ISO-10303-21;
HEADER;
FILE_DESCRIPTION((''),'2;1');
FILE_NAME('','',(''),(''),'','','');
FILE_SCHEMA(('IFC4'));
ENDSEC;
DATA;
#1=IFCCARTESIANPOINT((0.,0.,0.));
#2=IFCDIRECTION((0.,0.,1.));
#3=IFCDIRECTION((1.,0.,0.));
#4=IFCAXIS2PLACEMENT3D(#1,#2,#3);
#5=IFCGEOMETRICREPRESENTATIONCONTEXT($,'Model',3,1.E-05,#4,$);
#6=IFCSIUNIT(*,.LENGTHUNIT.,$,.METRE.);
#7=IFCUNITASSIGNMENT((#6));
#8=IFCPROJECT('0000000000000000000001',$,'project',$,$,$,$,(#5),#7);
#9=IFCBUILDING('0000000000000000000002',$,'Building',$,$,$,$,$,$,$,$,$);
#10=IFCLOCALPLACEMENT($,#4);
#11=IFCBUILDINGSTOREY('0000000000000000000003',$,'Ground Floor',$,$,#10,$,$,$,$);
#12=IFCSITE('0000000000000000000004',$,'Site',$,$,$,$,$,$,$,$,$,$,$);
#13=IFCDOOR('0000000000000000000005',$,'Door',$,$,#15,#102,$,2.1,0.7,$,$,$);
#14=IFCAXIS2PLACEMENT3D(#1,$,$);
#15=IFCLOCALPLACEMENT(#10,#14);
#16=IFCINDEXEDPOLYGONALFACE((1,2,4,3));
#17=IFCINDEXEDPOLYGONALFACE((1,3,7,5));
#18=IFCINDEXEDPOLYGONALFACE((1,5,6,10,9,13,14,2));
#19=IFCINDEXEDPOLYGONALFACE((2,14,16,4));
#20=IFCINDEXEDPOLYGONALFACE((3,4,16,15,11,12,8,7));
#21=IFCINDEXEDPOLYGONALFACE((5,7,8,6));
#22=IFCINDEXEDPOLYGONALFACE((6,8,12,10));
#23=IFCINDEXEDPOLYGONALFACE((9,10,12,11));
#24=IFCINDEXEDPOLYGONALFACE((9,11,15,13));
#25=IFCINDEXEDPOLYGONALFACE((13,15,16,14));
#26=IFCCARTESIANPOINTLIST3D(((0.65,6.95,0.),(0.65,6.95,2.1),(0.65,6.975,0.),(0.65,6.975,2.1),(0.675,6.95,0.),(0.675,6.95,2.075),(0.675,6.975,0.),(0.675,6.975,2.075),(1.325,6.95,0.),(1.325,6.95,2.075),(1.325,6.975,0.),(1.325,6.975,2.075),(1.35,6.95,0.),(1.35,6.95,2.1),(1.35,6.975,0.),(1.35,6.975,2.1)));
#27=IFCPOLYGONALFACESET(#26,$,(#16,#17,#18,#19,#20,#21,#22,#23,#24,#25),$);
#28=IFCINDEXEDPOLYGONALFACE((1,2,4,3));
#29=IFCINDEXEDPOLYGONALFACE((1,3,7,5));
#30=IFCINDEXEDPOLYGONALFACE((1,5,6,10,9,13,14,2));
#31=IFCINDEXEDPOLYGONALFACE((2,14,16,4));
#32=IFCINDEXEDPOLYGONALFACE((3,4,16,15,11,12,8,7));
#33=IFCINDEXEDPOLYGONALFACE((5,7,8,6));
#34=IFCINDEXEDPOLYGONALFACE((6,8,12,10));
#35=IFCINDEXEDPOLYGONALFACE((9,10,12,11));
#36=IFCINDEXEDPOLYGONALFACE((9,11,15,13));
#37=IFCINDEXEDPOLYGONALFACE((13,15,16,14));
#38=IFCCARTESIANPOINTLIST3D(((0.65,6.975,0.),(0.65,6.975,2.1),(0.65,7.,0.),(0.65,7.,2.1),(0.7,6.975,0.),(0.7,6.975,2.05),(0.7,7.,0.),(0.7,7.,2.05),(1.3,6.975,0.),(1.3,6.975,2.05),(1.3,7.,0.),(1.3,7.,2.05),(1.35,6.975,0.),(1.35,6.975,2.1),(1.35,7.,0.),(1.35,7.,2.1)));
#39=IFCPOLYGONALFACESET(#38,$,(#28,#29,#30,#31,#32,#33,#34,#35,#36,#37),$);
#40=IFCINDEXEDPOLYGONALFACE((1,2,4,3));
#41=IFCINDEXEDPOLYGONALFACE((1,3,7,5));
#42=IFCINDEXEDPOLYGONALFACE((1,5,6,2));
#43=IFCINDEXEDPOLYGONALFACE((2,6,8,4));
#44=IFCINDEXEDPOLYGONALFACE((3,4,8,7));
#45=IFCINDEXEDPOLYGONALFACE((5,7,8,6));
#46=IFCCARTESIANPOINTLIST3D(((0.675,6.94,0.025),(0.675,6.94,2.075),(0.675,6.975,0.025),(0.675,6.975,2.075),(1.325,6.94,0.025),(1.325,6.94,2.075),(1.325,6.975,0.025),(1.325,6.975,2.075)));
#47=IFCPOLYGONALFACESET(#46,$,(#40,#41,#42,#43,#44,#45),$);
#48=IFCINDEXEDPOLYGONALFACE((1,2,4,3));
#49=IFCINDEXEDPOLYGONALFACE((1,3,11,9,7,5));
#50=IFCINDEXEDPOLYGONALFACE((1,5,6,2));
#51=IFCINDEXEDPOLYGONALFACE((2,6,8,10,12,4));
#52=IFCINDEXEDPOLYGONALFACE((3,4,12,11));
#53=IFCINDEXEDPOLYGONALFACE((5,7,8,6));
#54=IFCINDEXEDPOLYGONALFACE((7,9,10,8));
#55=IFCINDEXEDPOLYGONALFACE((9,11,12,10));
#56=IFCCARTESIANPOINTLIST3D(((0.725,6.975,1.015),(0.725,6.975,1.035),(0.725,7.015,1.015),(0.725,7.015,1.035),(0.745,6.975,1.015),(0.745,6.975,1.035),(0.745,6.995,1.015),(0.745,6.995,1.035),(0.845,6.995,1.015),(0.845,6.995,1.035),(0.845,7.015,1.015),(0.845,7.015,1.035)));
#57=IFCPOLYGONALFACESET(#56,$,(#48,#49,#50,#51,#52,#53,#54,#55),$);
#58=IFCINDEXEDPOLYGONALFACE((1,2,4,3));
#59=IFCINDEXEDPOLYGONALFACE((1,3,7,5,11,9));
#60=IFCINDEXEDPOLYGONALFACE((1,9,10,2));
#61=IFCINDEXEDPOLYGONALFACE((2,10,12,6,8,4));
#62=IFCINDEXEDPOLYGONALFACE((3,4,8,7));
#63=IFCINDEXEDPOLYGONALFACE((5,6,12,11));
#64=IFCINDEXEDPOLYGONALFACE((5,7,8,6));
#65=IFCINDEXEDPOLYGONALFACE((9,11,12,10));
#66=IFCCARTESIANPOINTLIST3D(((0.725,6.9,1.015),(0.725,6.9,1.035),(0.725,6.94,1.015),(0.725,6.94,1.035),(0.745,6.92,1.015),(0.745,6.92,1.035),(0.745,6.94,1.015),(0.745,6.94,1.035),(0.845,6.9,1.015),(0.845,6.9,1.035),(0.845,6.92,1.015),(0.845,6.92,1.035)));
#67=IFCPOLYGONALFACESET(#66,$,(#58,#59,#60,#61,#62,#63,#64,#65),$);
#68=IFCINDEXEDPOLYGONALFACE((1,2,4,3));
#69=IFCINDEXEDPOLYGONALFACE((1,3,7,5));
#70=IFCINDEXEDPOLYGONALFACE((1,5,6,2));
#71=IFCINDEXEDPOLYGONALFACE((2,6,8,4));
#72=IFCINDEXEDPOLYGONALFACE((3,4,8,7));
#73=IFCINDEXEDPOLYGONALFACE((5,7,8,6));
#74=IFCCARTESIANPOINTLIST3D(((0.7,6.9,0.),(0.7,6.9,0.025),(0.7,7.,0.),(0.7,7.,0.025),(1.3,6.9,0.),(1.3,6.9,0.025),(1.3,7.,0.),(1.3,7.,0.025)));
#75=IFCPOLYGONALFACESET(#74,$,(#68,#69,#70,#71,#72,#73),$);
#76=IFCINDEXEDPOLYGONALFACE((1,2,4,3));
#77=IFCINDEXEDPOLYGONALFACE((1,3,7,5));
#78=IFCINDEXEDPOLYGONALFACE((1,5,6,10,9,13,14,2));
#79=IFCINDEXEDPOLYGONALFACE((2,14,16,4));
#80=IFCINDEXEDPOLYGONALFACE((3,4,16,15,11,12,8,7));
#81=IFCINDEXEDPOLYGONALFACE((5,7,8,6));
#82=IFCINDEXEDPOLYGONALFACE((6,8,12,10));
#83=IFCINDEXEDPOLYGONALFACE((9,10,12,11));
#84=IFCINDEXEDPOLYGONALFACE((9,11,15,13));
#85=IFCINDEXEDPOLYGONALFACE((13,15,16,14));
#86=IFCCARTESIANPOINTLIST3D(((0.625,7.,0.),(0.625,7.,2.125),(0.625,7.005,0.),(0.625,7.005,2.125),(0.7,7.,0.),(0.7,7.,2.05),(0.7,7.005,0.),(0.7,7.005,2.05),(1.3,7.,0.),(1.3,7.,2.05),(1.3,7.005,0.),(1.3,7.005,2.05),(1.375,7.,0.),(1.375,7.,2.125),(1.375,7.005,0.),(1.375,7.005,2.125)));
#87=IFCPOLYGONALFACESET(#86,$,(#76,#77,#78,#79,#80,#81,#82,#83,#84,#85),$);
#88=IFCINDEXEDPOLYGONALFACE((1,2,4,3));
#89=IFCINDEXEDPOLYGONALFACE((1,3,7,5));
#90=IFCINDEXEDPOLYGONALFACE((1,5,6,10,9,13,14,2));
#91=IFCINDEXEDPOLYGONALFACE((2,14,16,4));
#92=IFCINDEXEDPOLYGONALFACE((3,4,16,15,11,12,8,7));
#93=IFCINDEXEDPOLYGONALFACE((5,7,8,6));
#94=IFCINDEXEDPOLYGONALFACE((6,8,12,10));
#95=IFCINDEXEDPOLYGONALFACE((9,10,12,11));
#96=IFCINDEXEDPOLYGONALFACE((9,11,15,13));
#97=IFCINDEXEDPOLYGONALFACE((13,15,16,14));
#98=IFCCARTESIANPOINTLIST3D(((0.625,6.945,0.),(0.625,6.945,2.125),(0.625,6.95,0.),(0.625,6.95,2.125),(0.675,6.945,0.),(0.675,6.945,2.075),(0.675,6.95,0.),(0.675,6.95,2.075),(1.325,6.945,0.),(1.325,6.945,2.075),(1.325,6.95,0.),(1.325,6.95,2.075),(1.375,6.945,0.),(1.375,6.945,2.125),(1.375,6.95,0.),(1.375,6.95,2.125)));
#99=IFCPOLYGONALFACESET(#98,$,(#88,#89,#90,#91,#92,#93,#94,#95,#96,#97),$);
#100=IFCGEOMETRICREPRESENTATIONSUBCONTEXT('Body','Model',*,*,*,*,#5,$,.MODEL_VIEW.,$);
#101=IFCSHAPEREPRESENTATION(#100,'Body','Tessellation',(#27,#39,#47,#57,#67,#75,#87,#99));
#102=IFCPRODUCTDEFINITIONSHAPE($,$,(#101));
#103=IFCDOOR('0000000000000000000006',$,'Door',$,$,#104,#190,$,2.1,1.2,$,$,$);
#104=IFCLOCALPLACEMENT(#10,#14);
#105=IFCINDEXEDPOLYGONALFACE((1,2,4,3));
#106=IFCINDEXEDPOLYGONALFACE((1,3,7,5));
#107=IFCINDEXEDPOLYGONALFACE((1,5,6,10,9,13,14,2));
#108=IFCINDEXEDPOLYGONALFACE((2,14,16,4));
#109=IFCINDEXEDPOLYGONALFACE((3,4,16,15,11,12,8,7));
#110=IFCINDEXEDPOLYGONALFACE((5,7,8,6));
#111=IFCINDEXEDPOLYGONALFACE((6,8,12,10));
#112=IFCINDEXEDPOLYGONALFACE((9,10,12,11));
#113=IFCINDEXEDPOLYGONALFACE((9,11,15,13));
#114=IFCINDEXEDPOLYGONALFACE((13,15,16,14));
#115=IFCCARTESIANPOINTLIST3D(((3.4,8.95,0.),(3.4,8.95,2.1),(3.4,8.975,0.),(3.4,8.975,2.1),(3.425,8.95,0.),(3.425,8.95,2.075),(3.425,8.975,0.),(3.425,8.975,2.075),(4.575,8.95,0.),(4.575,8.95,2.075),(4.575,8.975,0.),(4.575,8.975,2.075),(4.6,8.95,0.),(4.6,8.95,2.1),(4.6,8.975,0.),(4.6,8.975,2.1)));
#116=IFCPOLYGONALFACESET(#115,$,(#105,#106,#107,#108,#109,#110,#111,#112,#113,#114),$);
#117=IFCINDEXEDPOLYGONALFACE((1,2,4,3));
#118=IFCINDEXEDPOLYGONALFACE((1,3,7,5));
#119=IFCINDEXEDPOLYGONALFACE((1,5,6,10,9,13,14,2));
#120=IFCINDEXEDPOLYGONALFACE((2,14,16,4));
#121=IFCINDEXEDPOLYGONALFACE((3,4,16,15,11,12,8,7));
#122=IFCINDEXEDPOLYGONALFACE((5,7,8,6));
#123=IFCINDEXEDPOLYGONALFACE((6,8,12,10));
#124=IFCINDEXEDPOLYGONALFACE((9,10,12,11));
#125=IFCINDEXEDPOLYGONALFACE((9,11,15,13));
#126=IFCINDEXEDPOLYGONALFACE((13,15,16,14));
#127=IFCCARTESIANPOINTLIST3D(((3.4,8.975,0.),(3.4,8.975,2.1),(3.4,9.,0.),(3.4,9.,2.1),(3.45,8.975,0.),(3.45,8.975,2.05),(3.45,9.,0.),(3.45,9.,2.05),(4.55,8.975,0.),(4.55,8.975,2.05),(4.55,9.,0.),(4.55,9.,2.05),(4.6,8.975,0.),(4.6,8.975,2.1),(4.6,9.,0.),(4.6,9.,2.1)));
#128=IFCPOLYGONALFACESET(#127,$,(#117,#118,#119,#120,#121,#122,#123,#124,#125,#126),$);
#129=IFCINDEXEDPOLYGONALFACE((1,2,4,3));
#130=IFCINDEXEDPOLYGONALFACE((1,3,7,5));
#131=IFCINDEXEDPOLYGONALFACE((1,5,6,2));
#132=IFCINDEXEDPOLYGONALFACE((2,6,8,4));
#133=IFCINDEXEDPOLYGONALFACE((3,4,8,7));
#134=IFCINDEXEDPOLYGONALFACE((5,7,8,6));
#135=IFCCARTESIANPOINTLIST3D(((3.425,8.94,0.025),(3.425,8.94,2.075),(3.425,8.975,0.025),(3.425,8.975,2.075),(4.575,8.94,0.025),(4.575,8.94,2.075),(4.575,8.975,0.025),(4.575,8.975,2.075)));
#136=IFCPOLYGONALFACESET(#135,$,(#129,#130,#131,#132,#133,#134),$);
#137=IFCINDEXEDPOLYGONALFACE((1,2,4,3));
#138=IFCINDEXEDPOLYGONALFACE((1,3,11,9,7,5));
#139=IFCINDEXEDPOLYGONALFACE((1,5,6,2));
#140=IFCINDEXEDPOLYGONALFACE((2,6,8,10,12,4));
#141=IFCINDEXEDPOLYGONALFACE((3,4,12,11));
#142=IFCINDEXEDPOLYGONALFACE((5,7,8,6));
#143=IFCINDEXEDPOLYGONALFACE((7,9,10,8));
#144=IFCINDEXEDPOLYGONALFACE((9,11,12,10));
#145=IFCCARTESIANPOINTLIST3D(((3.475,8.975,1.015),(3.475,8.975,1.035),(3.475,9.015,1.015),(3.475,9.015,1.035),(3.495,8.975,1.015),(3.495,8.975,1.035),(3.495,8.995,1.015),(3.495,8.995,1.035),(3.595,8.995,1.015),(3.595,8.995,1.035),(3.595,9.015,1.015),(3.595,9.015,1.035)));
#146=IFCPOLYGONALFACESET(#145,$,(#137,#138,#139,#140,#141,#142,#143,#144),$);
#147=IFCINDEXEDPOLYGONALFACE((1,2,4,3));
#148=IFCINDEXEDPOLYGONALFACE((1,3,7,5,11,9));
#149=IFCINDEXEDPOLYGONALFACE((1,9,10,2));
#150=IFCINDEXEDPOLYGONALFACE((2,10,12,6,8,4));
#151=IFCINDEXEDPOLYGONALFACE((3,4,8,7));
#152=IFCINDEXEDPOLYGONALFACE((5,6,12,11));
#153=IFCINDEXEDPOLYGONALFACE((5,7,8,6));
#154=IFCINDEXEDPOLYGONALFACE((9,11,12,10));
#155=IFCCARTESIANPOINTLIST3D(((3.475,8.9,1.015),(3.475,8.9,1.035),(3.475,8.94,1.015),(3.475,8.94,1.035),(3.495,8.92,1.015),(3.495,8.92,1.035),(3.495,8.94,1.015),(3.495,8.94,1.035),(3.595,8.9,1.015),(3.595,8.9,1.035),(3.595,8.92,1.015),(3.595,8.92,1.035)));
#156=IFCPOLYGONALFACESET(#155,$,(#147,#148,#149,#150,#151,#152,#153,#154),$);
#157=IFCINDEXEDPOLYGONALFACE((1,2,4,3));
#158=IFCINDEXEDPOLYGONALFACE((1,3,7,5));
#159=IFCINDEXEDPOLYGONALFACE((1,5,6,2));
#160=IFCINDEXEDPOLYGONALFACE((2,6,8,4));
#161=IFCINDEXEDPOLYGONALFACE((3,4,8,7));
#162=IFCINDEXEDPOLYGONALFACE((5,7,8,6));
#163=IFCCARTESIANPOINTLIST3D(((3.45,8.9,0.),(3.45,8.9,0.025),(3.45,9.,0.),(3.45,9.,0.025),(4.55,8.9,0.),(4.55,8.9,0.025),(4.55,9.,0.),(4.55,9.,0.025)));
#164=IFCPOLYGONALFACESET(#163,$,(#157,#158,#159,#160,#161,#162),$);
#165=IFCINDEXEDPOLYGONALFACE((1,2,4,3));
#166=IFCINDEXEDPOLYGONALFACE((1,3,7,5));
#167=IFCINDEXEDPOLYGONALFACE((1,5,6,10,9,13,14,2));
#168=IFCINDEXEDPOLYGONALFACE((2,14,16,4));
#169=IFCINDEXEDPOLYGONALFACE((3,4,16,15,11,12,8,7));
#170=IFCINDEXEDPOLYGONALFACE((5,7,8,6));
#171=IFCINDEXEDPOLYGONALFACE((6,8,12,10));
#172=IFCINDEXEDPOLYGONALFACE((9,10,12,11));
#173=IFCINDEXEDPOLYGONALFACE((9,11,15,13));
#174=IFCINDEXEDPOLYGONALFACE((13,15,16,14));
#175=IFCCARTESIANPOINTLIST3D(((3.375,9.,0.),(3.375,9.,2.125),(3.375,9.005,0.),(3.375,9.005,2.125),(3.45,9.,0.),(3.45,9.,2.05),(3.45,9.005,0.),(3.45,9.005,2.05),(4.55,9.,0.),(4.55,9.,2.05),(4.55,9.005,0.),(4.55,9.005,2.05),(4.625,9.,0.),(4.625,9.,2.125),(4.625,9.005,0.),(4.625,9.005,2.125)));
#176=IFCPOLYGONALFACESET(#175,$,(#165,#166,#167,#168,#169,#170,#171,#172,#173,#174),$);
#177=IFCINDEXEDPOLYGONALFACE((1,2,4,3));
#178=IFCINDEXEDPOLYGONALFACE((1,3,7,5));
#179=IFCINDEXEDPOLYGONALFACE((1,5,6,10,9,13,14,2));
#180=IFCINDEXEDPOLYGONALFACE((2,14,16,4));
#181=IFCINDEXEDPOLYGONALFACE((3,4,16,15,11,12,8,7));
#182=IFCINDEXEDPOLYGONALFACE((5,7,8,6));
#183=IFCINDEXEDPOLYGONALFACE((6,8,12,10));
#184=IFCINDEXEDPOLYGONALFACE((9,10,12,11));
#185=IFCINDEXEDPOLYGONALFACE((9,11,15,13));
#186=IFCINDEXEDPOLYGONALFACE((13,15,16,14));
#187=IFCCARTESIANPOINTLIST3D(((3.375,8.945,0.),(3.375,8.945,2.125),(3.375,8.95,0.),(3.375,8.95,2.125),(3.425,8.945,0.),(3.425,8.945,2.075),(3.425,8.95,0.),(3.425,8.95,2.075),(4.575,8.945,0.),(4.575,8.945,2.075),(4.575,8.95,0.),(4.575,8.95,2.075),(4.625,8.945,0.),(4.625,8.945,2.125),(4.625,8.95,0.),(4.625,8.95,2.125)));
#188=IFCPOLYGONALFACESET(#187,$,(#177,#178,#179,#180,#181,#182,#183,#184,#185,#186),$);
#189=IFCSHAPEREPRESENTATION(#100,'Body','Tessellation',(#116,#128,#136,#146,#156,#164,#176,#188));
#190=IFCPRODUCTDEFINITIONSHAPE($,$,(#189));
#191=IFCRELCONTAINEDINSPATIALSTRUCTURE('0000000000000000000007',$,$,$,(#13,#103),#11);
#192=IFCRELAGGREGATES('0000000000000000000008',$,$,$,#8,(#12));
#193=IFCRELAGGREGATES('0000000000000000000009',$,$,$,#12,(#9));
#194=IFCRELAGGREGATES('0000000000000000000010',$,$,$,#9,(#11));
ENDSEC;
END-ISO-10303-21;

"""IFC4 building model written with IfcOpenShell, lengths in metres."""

from ifc_helpers import new_model, si_unit, frame, origin_with_axes, place, context, subcontext, project, spatial, line, indexed_curve, outline, extrude, element, save


model = new_model("IFC4")

# Units and contexts
model_context = context("Model", 3, precision=1e-05, world=origin_with_axes())
body_context = subcontext(model_context, "Body", "Model", "MODEL_VIEW")
ifc_project = project(units=[si_unit("LENGTHUNIT", "METRE")], contexts=[model_context])

# Site, building, storey
site = spatial("IfcSite", under=ifc_project, Name="Site")
building = spatial("IfcBuilding", under=site, Name="Building")
storey_placement = place(None, origin_with_axes())
storey = spatial("IfcBuildingStorey", under=building, at=storey_placement, Name="Ground Floor")

# Doors
door_1_placement = place(storey_placement, frame((1.35, 7.0, 0.0), z_axis=(0.0, 0.0, 1.0), x_axis=(-1.0, 0.0, 0.0)))
element("IfcDoor", 1, at=door_1_placement, inside=storey, Name="Door", OverallHeight=2.1, OverallWidth=0.7, context=body_context, shape_type="SweptSolid", body=[
    extrude(outline(indexed_curve([(0.0, 0.0), (0.0, 2.1), (0.7, 2.1), (0.7, 0.0), (0.675, 0.0), (0.675, 2.075), (0.025, 2.075), (0.025, 0.0)], segments=[line(1, 2, 3, 4, 5, 6, 7, 8, 1)])), frame((0.0, 0.025, 0.0), z_axis=(0.0, -1.0, 0.0), x_axis=(1.0, 0.0, 0.0)), (0.0, 0.0, -1.0), 0.025),
    extrude(outline(indexed_curve([(0.0, 0.0), (0.0, 2.1), (0.7, 2.1), (0.7, 0.0), (0.65, 0.0), (0.65, 2.05), (0.05, 2.05), (0.05, 0.0)], segments=[line(1, 2, 3, 4, 5, 6, 7, 8, 1)])), frame((0.0, 0.0, 0.0), z_axis=(0.0, -1.0, 0.0), x_axis=(1.0, 0.0, 0.0)), (0.0, 0.0, -1.0), 0.025),
    extrude(outline(indexed_curve([(0.0, 0.0), (0.65, 0.0), (0.65, 0.035), (0.0, 0.035)], segments=[line(1, 2, 3, 4, 1)])), frame((0.025, 0.025, 0.025), z_axis=(0.0, 0.0, 1.0), x_axis=(1.0, 0.0, 0.0)), (0.0, 0.0, 1.0), 2.05),
    extrude(outline(indexed_curve([(0.0, 0.0), (0.0, -0.04), (-0.12, -0.04), (-0.12, -0.02), (-0.02, -0.02), (-0.02, 0.0)], segments=[line(1, 2, 3, 4, 5, 6, 1)])), frame((0.625, 0.025, 1.015), z_axis=(0.0, 0.0, 1.0), x_axis=(1.0, 0.0, 0.0)), (0.0, 0.0, 1.0), 0.02),
    extrude(outline(indexed_curve([(0.0, 0.0), (0.0, 0.04), (-0.12, 0.04), (-0.12, 0.02), (-0.02, 0.02), (-0.02, 0.0)], segments=[line(1, 2, 3, 4, 5, 6, 1)])), frame((0.625, 0.06, 1.015), z_axis=(0.0, 0.0, 1.0), x_axis=(1.0, 0.0, 0.0)), (0.0, 0.0, 1.0), 0.02),
    extrude(outline(indexed_curve([(0.0, 0.0), (0.6, 0.0), (0.6, 0.1), (0.0, 0.1)], segments=[line(1, 2, 3, 4, 1)])), frame((0.05, 0.0, 0.0), z_axis=(0.0, 0.0, 1.0), x_axis=(1.0, 0.0, 0.0)), (0.0, 0.0, 1.0), 0.025),
    extrude(outline(indexed_curve([(0.0, 0.0), (0.0, 2.125), (0.75, 2.125), (0.75, 0.0), (0.675, 0.0), (0.675, 2.05), (0.075, 2.05), (0.075, 0.0)], segments=[line(1, 2, 3, 4, 5, 6, 7, 8, 1)])), frame((-0.025, -0.005, 0.0), z_axis=(0.0, -1.0, 0.0), x_axis=(1.0, 0.0, 0.0)), (0.0, 0.0, -1.0), 0.005),
    extrude(outline(indexed_curve([(0.0, 0.0), (0.0, 2.125), (0.75, 2.125), (0.75, 0.0), (0.7, 0.0), (0.7, 2.075), (0.05, 2.075), (0.05, 0.0)], segments=[line(1, 2, 3, 4, 5, 6, 7, 8, 1)])), frame((-0.025, 0.05, 0.0), z_axis=(0.0, -1.0, 0.0), x_axis=(1.0, 0.0, 0.0)), (0.0, 0.0, -1.0), 0.005),
])
door_2_placement = place(storey_placement, frame((4.6, 9.0, 0.0), z_axis=(0.0, 0.0, 1.0), x_axis=(-1.0, 0.0, 0.0)))
element("IfcDoor", 2, at=door_2_placement, inside=storey, Name="Door", OverallHeight=2.1, OverallWidth=1.2, context=body_context, shape_type="SweptSolid", body=[
    extrude(outline(indexed_curve([(0.0, 0.0), (0.0, 2.1), (1.2, 2.1), (1.2, 0.0), (1.175, 0.0), (1.175, 2.075), (0.025, 2.075), (0.025, 0.0)], segments=[line(1, 2, 3, 4, 5, 6, 7, 8, 1)])), frame((0.0, 0.025, 0.0), z_axis=(0.0, -1.0, 0.0), x_axis=(1.0, 0.0, 0.0)), (0.0, 0.0, -1.0), 0.025),
    extrude(outline(indexed_curve([(0.0, 0.0), (0.0, 2.1), (1.2, 2.1), (1.2, 0.0), (1.15, 0.0), (1.15, 2.05), (0.05, 2.05), (0.05, 0.0)], segments=[line(1, 2, 3, 4, 5, 6, 7, 8, 1)])), frame((0.0, 0.0, 0.0), z_axis=(0.0, -1.0, 0.0), x_axis=(1.0, 0.0, 0.0)), (0.0, 0.0, -1.0), 0.025),
    extrude(outline(indexed_curve([(0.0, 0.0), (1.15, 0.0), (1.15, 0.035), (0.0, 0.035)], segments=[line(1, 2, 3, 4, 1)])), frame((0.025, 0.025, 0.025), z_axis=(0.0, 0.0, 1.0), x_axis=(1.0, 0.0, 0.0)), (0.0, 0.0, 1.0), 2.05),
    extrude(outline(indexed_curve([(0.0, 0.0), (0.0, -0.04), (-0.12, -0.04), (-0.12, -0.02), (-0.02, -0.02), (-0.02, 0.0)], segments=[line(1, 2, 3, 4, 5, 6, 1)])), frame((1.125, 0.025, 1.015), z_axis=(0.0, 0.0, 1.0), x_axis=(1.0, 0.0, 0.0)), (0.0, 0.0, 1.0), 0.02),
    extrude(outline(indexed_curve([(0.0, 0.0), (0.0, 0.04), (-0.12, 0.04), (-0.12, 0.02), (-0.02, 0.02), (-0.02, 0.0)], segments=[line(1, 2, 3, 4, 5, 6, 1)])), frame((1.125, 0.06, 1.015), z_axis=(0.0, 0.0, 1.0), x_axis=(1.0, 0.0, 0.0)), (0.0, 0.0, 1.0), 0.02),
    extrude(outline(indexed_curve([(0.0, 0.0), (1.1, 0.0), (1.1, 0.1), (0.0, 0.1)], segments=[line(1, 2, 3, 4, 1)])), frame((0.05, 0.0, 0.0), z_axis=(0.0, 0.0, 1.0), x_axis=(1.0, 0.0, 0.0)), (0.0, 0.0, 1.0), 0.025),
    extrude(outline(indexed_curve([(0.0, 0.0), (0.0, 2.125), (1.25, 2.125), (1.25, 0.0), (1.175, 0.0), (1.175, 2.05), (0.075, 2.05), (0.075, 0.0)], segments=[line(1, 2, 3, 4, 5, 6, 7, 8, 1)])), frame((-0.025, -0.005, 0.0), z_axis=(0.0, -1.0, 0.0), x_axis=(1.0, 0.0, 0.0)), (0.0, 0.0, -1.0), 0.005),
    extrude(outline(indexed_curve([(0.0, 0.0), (0.0, 2.125), (1.25, 2.125), (1.25, 0.0), (1.2, 0.0), (1.2, 2.075), (0.05, 2.075), (0.05, 0.0)], segments=[line(1, 2, 3, 4, 5, 6, 7, 8, 1)])), frame((-0.025, 0.05, 0.0), z_axis=(0.0, -1.0, 0.0), x_axis=(1.0, 0.0, 0.0)), (0.0, 0.0, -1.0), 0.005),
])

save(model, "model.ifc")
